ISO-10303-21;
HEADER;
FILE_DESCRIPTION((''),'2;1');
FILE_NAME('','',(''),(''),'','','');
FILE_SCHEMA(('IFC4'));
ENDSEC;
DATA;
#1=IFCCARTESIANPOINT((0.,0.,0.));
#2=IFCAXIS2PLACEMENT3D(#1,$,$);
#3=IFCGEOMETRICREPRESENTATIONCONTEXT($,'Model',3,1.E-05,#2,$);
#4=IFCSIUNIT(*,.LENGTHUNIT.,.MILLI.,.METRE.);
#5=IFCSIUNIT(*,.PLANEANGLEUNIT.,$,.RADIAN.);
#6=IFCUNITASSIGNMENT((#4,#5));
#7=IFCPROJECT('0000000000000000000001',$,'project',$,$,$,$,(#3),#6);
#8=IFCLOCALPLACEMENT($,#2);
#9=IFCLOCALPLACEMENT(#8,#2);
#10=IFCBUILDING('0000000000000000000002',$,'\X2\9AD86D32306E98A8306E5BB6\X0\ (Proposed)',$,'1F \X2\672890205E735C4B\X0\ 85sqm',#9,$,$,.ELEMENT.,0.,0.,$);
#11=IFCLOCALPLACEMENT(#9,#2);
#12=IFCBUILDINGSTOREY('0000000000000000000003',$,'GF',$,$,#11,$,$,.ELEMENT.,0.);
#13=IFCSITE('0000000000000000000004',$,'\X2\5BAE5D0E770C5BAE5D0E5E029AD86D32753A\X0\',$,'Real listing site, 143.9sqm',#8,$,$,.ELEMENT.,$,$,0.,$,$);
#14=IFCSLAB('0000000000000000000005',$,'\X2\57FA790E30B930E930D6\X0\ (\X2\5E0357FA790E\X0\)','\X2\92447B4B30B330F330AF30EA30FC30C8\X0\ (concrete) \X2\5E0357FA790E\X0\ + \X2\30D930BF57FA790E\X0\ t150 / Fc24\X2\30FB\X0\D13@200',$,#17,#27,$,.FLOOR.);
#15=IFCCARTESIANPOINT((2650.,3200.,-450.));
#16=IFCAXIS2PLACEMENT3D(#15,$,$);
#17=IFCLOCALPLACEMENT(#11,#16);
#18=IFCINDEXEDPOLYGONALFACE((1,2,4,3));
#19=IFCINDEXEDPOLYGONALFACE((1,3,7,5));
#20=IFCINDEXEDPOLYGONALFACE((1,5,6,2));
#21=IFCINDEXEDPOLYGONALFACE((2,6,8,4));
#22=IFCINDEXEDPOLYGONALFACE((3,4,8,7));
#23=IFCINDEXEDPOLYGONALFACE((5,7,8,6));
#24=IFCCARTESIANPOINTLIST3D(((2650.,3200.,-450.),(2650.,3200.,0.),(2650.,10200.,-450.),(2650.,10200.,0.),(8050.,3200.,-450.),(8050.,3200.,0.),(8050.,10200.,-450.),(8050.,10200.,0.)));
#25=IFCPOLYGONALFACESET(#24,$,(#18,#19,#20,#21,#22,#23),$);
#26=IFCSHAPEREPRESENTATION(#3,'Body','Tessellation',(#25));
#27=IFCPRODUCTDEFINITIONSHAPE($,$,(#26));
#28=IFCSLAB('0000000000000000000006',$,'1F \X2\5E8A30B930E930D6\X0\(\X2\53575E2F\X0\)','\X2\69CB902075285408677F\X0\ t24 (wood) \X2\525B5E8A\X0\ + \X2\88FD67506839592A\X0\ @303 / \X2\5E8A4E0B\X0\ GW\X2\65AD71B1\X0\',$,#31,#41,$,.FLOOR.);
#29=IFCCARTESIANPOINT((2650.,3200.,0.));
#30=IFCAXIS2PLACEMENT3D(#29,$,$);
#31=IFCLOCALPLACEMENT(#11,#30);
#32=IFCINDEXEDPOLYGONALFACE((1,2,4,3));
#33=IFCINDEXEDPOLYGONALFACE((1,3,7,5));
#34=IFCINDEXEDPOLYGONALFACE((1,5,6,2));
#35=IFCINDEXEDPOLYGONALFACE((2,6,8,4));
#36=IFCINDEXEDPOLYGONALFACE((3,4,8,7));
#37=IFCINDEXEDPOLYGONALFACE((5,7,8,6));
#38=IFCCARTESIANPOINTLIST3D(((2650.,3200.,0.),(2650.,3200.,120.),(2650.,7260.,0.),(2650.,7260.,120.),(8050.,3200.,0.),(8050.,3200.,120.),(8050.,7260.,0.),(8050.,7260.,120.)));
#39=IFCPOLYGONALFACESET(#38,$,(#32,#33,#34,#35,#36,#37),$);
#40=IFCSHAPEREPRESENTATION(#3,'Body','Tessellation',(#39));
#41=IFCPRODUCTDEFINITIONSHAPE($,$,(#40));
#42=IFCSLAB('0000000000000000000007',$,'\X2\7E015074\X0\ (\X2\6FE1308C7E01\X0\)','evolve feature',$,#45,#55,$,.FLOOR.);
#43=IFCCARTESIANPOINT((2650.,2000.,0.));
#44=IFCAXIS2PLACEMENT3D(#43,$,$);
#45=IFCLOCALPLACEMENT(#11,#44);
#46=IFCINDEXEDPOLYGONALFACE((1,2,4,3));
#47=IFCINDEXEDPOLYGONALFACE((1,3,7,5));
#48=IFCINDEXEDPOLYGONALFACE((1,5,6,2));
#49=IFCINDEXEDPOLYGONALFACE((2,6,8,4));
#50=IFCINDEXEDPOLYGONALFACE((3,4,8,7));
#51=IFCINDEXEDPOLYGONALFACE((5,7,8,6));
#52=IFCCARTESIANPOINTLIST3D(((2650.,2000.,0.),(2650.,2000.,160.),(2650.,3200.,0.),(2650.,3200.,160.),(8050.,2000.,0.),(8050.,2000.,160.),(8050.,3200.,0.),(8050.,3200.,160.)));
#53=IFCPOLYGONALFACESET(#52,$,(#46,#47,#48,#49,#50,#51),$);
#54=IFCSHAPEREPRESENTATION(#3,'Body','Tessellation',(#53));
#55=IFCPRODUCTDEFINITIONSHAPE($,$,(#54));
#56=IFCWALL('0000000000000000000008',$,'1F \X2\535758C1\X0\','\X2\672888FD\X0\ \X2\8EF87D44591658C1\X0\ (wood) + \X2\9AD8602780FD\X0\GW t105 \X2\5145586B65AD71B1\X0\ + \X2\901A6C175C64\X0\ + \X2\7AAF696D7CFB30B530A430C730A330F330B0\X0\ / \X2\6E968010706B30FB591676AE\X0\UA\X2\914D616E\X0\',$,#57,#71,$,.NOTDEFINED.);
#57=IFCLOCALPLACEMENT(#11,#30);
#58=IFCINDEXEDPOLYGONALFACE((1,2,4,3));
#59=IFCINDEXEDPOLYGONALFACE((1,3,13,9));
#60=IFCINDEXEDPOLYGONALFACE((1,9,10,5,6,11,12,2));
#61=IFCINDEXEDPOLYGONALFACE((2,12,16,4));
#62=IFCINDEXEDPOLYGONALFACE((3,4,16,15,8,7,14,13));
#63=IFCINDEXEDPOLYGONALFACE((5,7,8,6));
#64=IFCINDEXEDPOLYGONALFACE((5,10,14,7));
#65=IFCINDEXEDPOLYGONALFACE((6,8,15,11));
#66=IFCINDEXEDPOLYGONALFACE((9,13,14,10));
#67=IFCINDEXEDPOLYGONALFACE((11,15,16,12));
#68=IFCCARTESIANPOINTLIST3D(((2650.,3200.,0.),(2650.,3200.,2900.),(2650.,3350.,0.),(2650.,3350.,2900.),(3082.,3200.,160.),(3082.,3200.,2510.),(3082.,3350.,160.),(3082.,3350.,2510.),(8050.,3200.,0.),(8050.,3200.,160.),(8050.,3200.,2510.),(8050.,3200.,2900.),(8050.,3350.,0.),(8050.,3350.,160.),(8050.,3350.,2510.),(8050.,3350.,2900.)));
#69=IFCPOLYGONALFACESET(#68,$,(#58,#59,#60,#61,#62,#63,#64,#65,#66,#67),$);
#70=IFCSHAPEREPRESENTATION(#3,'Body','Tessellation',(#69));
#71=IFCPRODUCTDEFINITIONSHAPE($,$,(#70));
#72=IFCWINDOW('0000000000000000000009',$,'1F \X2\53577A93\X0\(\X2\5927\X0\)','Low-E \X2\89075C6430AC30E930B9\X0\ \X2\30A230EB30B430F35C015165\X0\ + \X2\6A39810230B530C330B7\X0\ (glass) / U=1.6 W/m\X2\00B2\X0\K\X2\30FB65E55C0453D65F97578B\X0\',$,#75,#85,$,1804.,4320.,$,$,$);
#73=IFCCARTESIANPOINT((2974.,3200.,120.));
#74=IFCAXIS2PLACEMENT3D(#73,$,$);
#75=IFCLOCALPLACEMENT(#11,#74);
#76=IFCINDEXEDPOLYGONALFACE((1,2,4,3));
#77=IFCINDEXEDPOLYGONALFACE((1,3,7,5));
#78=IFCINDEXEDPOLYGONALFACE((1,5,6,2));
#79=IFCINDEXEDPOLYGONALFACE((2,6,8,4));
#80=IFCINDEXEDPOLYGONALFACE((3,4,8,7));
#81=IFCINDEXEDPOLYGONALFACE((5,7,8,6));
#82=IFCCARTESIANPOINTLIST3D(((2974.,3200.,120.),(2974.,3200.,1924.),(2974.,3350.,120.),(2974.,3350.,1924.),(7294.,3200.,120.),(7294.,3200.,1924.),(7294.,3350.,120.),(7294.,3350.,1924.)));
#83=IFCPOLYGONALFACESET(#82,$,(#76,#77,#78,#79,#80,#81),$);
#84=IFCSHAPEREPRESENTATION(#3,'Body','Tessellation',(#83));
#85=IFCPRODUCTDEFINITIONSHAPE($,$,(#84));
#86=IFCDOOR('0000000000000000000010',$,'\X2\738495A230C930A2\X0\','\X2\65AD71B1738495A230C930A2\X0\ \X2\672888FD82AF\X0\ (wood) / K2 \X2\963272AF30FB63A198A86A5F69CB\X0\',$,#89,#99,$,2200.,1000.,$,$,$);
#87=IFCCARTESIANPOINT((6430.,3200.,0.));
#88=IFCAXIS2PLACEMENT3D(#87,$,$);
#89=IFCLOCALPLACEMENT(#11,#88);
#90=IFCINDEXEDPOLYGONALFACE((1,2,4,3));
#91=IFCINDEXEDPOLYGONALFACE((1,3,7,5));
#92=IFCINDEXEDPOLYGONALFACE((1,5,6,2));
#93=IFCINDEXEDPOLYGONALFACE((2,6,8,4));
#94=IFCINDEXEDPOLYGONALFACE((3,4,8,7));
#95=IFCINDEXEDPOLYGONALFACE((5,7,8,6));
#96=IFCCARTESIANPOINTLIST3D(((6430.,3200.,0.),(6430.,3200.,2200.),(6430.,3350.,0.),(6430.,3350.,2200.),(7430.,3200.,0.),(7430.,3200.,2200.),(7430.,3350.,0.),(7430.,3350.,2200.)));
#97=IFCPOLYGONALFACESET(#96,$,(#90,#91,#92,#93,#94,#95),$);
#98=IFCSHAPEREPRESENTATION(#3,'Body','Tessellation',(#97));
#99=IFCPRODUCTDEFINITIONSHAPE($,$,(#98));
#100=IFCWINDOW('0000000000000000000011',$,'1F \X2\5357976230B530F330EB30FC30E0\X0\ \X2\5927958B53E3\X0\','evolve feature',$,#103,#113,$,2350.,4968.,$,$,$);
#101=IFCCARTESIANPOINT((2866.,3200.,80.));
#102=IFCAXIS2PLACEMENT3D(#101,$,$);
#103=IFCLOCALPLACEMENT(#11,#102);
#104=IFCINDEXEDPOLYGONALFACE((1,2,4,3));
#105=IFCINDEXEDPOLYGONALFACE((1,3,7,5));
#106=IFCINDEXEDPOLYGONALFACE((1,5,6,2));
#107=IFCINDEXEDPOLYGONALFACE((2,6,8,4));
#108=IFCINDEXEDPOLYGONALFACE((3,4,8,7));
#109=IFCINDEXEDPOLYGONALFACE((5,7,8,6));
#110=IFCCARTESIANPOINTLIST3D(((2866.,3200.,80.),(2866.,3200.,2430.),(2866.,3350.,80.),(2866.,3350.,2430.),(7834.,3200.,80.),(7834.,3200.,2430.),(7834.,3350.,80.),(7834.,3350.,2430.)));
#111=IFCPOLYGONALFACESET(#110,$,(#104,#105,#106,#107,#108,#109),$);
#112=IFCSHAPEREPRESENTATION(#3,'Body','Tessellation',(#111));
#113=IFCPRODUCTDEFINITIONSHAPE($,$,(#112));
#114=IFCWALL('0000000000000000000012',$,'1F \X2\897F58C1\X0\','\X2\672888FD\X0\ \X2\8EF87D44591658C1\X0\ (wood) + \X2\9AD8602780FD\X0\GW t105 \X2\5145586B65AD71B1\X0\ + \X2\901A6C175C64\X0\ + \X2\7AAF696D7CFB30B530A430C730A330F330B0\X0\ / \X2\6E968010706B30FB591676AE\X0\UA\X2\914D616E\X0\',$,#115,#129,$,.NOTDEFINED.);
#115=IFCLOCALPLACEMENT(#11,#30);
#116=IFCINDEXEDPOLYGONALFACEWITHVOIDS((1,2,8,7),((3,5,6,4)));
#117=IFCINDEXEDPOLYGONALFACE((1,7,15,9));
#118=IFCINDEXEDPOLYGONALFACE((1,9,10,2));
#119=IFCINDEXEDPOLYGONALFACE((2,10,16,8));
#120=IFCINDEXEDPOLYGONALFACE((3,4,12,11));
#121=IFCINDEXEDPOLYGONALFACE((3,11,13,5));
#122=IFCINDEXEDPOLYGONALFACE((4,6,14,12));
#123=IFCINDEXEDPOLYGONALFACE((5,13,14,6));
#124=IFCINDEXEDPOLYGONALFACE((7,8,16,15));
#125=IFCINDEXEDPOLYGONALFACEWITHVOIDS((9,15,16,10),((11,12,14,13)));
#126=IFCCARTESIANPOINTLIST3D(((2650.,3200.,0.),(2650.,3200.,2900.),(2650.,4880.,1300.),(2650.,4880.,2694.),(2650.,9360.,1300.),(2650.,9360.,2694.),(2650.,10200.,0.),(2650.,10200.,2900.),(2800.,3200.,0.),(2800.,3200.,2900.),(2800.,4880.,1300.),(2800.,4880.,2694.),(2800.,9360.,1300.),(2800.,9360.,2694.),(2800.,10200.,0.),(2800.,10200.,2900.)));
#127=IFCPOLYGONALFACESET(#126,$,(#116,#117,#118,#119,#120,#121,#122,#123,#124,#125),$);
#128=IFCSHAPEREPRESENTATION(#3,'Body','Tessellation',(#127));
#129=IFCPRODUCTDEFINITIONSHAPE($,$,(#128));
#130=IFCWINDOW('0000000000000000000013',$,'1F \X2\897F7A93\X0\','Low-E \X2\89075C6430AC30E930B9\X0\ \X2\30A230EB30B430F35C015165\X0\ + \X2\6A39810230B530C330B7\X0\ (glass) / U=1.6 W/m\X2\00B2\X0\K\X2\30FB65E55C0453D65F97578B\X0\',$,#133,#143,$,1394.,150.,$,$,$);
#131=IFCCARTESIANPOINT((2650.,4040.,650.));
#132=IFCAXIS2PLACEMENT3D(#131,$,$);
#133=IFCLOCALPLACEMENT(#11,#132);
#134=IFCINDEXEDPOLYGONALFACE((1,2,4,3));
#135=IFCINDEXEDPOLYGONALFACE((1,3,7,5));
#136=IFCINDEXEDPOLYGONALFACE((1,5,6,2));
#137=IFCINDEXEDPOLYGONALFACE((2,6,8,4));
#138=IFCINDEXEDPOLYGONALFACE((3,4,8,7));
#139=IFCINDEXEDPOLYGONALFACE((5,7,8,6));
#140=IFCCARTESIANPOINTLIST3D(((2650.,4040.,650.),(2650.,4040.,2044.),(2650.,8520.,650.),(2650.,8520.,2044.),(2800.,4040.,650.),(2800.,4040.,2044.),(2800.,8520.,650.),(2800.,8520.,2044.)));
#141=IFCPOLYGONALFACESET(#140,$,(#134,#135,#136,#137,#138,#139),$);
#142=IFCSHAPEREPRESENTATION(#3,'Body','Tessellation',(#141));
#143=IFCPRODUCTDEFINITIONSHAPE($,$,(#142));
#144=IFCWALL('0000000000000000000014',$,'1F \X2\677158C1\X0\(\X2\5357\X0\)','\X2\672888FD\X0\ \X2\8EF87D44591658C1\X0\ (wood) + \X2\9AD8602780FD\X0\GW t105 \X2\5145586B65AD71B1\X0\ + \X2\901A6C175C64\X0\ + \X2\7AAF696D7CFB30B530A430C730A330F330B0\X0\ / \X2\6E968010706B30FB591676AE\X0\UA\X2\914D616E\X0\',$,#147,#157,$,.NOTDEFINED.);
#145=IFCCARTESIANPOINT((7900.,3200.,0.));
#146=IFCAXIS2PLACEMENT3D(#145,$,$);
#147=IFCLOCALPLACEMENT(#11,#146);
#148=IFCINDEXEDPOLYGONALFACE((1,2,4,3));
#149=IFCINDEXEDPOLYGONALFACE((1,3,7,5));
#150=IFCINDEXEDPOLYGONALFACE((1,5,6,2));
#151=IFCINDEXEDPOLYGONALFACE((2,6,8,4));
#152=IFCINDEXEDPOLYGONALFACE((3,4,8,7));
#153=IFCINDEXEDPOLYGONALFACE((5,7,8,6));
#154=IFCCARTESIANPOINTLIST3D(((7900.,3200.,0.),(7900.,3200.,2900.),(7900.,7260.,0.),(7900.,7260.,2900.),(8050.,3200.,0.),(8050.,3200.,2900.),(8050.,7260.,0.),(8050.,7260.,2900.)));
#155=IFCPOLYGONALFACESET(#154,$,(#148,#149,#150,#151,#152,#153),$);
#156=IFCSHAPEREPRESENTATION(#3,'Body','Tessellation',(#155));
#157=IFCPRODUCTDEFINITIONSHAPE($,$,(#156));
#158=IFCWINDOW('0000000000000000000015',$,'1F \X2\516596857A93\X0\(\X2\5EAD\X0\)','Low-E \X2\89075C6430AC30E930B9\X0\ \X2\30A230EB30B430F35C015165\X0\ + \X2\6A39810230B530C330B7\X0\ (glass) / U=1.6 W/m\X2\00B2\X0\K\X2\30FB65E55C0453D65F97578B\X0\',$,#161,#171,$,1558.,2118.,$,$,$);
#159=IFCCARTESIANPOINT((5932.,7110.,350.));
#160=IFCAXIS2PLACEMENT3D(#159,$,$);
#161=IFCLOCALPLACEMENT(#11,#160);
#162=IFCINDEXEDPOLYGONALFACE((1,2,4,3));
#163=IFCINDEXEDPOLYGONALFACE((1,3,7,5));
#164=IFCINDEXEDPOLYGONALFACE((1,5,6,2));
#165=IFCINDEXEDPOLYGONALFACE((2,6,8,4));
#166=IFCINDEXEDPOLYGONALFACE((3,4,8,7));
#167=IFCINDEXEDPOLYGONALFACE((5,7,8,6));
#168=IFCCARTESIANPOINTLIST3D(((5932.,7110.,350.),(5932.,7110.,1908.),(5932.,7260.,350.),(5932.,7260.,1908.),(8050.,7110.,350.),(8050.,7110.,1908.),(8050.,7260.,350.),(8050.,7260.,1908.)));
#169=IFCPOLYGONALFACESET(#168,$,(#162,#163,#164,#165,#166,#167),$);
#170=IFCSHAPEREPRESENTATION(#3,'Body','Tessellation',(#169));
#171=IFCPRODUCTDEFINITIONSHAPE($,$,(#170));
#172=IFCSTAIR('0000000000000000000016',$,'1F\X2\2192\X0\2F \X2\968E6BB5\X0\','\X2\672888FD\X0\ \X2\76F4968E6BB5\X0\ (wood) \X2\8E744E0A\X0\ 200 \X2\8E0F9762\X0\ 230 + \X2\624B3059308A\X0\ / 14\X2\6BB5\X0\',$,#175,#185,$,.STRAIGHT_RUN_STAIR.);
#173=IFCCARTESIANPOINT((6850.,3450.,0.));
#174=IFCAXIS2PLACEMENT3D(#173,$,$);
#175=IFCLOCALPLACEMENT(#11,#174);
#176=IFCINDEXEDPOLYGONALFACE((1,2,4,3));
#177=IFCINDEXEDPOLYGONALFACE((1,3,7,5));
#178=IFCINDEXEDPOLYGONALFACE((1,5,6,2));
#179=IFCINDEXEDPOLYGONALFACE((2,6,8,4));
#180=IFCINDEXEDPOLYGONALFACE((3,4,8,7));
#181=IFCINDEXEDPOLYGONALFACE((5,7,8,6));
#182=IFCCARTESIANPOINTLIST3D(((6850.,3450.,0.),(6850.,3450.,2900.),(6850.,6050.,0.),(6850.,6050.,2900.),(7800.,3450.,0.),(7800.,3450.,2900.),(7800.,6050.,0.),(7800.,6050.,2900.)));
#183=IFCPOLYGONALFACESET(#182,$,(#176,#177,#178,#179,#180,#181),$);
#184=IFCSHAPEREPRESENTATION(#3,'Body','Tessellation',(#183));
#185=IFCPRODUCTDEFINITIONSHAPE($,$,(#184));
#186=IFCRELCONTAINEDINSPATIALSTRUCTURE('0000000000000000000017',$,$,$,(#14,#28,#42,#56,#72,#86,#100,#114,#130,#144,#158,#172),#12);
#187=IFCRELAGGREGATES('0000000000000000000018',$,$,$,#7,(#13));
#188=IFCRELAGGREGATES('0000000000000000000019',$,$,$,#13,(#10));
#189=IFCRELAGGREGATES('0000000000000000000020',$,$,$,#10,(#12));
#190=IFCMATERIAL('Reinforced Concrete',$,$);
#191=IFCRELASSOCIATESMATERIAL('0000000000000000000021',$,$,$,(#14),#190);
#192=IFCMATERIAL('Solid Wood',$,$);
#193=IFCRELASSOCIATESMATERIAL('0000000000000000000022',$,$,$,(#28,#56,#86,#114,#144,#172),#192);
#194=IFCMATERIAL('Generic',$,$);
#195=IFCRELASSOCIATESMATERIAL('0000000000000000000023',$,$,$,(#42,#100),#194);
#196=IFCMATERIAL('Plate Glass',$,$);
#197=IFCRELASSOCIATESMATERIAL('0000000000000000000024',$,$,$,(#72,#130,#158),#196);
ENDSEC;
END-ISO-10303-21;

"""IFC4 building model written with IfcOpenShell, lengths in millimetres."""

from ifc_helpers import new_model, si_unit, frame, frame_2d, origin, place, context, project, spatial, rectangle, extrude, material, element, fill, save


model = new_model("IFC4")

# Units and contexts
model_context = context("Model", 3, precision=1e-05, world=origin())
ifc_project = project(units=[si_unit("LENGTHUNIT", "METRE", prefix="MILLI"), si_unit("PLANEANGLEUNIT", "RADIAN")], contexts=[model_context])

# Site, building, storey
site_placement = place(None, origin())
site = spatial("IfcSite", under=ifc_project, at=site_placement, Name="宮崎県宮崎市高洲町", ObjectType="Real listing site, 143.9sqm", CompositionType="ELEMENT", RefElevation=0.0)
building_placement = place(site_placement, origin())
building = spatial("IfcBuilding", under=site, at=building_placement, Name="高洲の風の家 (Proposed)", ObjectType="1F 木造平屋 85sqm", CompositionType="ELEMENT", ElevationOfRefHeight=0.0, ElevationOfTerrain=0.0)
storey_placement = place(building_placement, origin())
storey = spatial("IfcBuildingStorey", under=building, at=storey_placement, Name="GF", CompositionType="ELEMENT", Elevation=0.0)

# Slabs
ifc_material_1 = material(Name="Reinforced Concrete")
slab_1_placement = place(storey_placement, frame((2650.0, 3200.0, -450.0)))
element("IfcSlab", 1, at=slab_1_placement, inside=storey, material=ifc_material_1, Name="基礎スラブ (布基礎)", Description="鉄筋コンクリート (concrete) 布基礎 + ベタ基礎 t150 / Fc24・D13@200", PredefinedType="FLOOR", context=model_context, shape_type="SweptSolid", body=[
    extrude(rectangle(XDim=5400.0, YDim=7000.0, at=frame_2d((2700.0, 3500.0))), frame((2650.0, 3200.0, -450.0)), (0.0, 0.0, 1.0), 450.0),
])
ifc_material_2 = material(Name="Solid Wood")
slab_2_placement = place(storey_placement, frame((2650.0, 3200.0, 0.0)))
element("IfcSlab", 2, at=slab_2_placement, inside=storey, material=ifc_material_2, Name="1F 床スラブ(南帯)", Description="構造用合板 t24 (wood) 剛床 + 製材根太 @303 / 床下 GW断熱", PredefinedType="FLOOR", context=model_context, shape_type="SweptSolid", body=[
    extrude(rectangle(XDim=5400.0, YDim=4060.0, at=frame_2d((2700.0, 2030.0))), frame((2650.0, 3200.0, 0.0)), (0.0, 0.0, 1.0), 120.0),
])
ifc_material_3 = material(Name="Generic")
slab_3_placement = place(storey_placement, frame((2650.0, 2000.0, 0.0)))
element("IfcSlab", 3, at=slab_3_placement, inside=storey, material=ifc_material_3, Name="縁側 (濡れ縁)", Description="evolve feature", PredefinedType="FLOOR", context=model_context, shape_type="SweptSolid", body=[
    extrude(rectangle(XDim=5400.0, YDim=1200.0, at=frame_2d((2700.0, 600.0))), frame((2650.0, 2000.0, 0.0)), (0.0, 0.0, 1.0), 160.0),
])

# Wall, openings, windows, door
wall_1_placement = place(storey_placement, frame((2650.0, 3200.0, 0.0)))
wall_1 = element("IfcWall", 4, at=wall_1_placement, inside=storey, material=ifc_material_2, Name="1F 南壁", Description="木製 軸組外壁 (wood) + 高性能GW t105 充填断熱 + 通気層 + 窯業系サイディング / 準耐火・外皮UA配慮", PredefinedType="NOTDEFINED", context=model_context, shape_type="SweptSolid", body=[
    extrude(rectangle(XDim=5400.0, YDim=150.0, at=frame_2d((2700.0, 75.0))), frame((2650.0, 3200.0, 0.0)), (0.0, 0.0, 1.0), 2900.0),
])
opening_1_placement = place(storey_placement, frame((2974.0, 3200.0, 120.0)))
opening_1 = element("IfcOpeningElement", 5, at=opening_1_placement, cuts=wall_1, PredefinedType="NOTDEFINED", context=model_context, shape_type="SweptSolid", body=[
    extrude(rectangle(XDim=4320.0, YDim=150.0, at=frame_2d((2160.0, 75.0))), frame((2974.0, 3200.0, 120.0)), (0.0, 0.0, 1.0), 1804.0),
])
opening_2_placement = place(storey_placement, frame((6430.0, 3200.0, 0.0)))
opening_2 = element("IfcOpeningElement", 6, at=opening_2_placement, cuts=wall_1, PredefinedType="NOTDEFINED", context=model_context, shape_type="SweptSolid", body=[
    extrude(rectangle(XDim=1000.0, YDim=150.0, at=frame_2d((500.0, 75.0))), frame((6430.0, 3200.0, 0.0)), (0.0, 0.0, 1.0), 2200.0),
])
opening_3_placement = place(storey_placement, frame((2866.0, 3200.0, 80.0)))
opening_3 = element("IfcOpeningElement", 7, at=opening_3_placement, cuts=wall_1, PredefinedType="NOTDEFINED", context=model_context, shape_type="SweptSolid", body=[
    extrude(rectangle(XDim=4968.0, YDim=150.0, at=frame_2d((2484.0, 75.0))), frame((2866.0, 3200.0, 80.0)), (0.0, 0.0, 1.0), 2350.0),
])
ifc_material_4 = material(Name="Plate Glass")
window_1_placement = place(storey_placement, frame((2974.0, 3200.0, 120.0)))
window_1 = element("IfcWindow", 8, at=window_1_placement, inside=storey, material=ifc_material_4, Name="1F 南窓(大)", Description="Low-E 複層ガラス アルゴン封入 + 樹脂サッシ (glass) / U=1.6 W/m²K・日射取得型", OverallHeight=1804.0, OverallWidth=4320.0, context=model_context, shape_type="SweptSolid", body=[
    extrude(rectangle(XDim=4320.0, YDim=150.0, at=frame_2d((2160.0, 75.0))), frame((2974.0, 3200.0, 120.0)), (0.0, 0.0, 1.0), 1804.0),
])
fill(opening_1, window_1)
door_1_placement = place(storey_placement, frame((6430.0, 3200.0, 0.0)))
door_1 = element("IfcDoor", 9, at=door_1_placement, inside=storey, material=ifc_material_2, Name="玄関ドア", Description="断熱玄関ドア 木製芯 (wood) / K2 防犯・採風機構", OverallHeight=2200.0, OverallWidth=1000.0, context=model_context, shape_type="SweptSolid", body=[
    extrude(rectangle(XDim=1000.0, YDim=150.0, at=frame_2d((500.0, 75.0))), frame((6430.0, 3200.0, 0.0)), (0.0, 0.0, 1.0), 2200.0),
])
fill(opening_2, door_1)
window_2_placement = place(storey_placement, frame((2866.0, 3200.0, 80.0)))
window_2 = element("IfcWindow", 10, at=window_2_placement, inside=storey, material=ifc_material_3, Name="1F 南面サンルーム 大開口", Description="evolve feature", OverallHeight=2350.0, OverallWidth=4968.0, context=model_context, shape_type="SweptSolid", body=[
    extrude(rectangle(XDim=4968.0, YDim=150.0, at=frame_2d((2484.0, 75.0))), frame((2866.0, 3200.0, 80.0)), (0.0, 0.0, 1.0), 2350.0),
])
fill(opening_3, window_2)

# Walls, openings, windows
wall_2_placement = place(storey_placement, frame((2650.0, 3200.0, 0.0)))
wall_2 = element("IfcWall", 11, at=wall_2_placement, inside=storey, material=ifc_material_2, Name="1F 西壁", Description="木製 軸組外壁 (wood) + 高性能GW t105 充填断熱 + 通気層 + 窯業系サイディング / 準耐火・外皮UA配慮", PredefinedType="NOTDEFINED", context=model_context, shape_type="SweptSolid", body=[
    extrude(rectangle(XDim=150.0, YDim=7000.0, at=frame_2d((75.0, 3500.0))), frame((2650.0, 3200.0, 0.0)), (0.0, 0.0, 1.0), 2900.0),
])
opening_4_placement = place(storey_placement, frame((2650.0, 4040.0, 650.0)))
opening_4 = element("IfcOpeningElement", 12, at=opening_4_placement, cuts=wall_2, PredefinedType="NOTDEFINED", context=model_context, shape_type="SweptSolid", body=[
    extrude(rectangle(XDim=150.0, YDim=4480.0, at=frame_2d((75.0, 2240.0))), frame((2650.0, 4040.0, 650.0)), (0.0, 0.0, 1.0), 1394.0),
])
window_3_placement = place(storey_placement, frame((2650.0, 4040.0, 650.0)))
window_3 = element("IfcWindow", 13, at=window_3_placement, inside=storey, material=ifc_material_4, Name="1F 西窓", Description="Low-E 複層ガラス アルゴン封入 + 樹脂サッシ (glass) / U=1.6 W/m²K・日射取得型", OverallHeight=1394.0, OverallWidth=150.0, context=model_context, shape_type="SweptSolid", body=[
    extrude(rectangle(XDim=150.0, YDim=4480.0, at=frame_2d((75.0, 2240.0))), frame((2650.0, 4040.0, 650.0)), (0.0, 0.0, 1.0), 1394.0),
])
fill(opening_4, window_3)
wall_3_placement = place(storey_placement, frame((7900.0, 3200.0, 0.0)))
wall_3 = element("IfcWall", 14, at=wall_3_placement, inside=storey, material=ifc_material_2, Name="1F 東壁(南)", Description="木製 軸組外壁 (wood) + 高性能GW t105 充填断熱 + 通気層 + 窯業系サイディング / 準耐火・外皮UA配慮", PredefinedType="NOTDEFINED", context=model_context, shape_type="SweptSolid", body=[
    extrude(rectangle(XDim=150.0, YDim=4060.0, at=frame_2d((75.0, 2030.0))), frame((7900.0, 3200.0, 0.0)), (0.0, 0.0, 1.0), 2900.0),
])
opening_5_placement = place(storey_placement, frame((5932.0, 7110.0, 350.0)))
opening_5 = element("IfcOpeningElement", 15, at=opening_5_placement, cuts=wall_3, PredefinedType="NOTDEFINED", context=model_context, shape_type="SweptSolid", body=[
    extrude(rectangle(XDim=2118.0, YDim=150.0, at=frame_2d((1059.0, 75.0))), frame((5932.0, 7110.0, 350.0)), (0.0, 0.0, 1.0), 1558.0),
])
window_4_placement = place(storey_placement, frame((5932.0, 7110.0, 350.0)))
window_4 = element("IfcWindow", 16, at=window_4_placement, inside=storey, material=ifc_material_4, Name="1F 入隅窓(庭)", Description="Low-E 複層ガラス アルゴン封入 + 樹脂サッシ (glass) / U=1.6 W/m²K・日射取得型", OverallHeight=1558.0, OverallWidth=2118.0, context=model_context, shape_type="SweptSolid", body=[
    extrude(rectangle(XDim=2118.0, YDim=150.0, at=frame_2d((1059.0, 75.0))), frame((5932.0, 7110.0, 350.0)), (0.0, 0.0, 1.0), 1558.0),
])
fill(opening_5, window_4)

# Stair
stair_placement = place(storey_placement, frame((6850.0, 3450.0, 0.0)))
element("IfcStair", 17, at=stair_placement, inside=storey, material=ifc_material_2, Name="1F→2F 階段", Description="木製 直階段 (wood) 蹴上 200 踏面 230 + 手すり / 14段", PredefinedType="STRAIGHT_RUN_STAIR", context=model_context, shape_type="SweptSolid", body=[
    extrude(rectangle(XDim=950.0, YDim=2600.0, at=frame_2d((475.0, 1300.0))), frame((6850.0, 3450.0, 0.0)), (0.0, 0.0, 1.0), 2900.0),
])

save(model, "model.ifc")
